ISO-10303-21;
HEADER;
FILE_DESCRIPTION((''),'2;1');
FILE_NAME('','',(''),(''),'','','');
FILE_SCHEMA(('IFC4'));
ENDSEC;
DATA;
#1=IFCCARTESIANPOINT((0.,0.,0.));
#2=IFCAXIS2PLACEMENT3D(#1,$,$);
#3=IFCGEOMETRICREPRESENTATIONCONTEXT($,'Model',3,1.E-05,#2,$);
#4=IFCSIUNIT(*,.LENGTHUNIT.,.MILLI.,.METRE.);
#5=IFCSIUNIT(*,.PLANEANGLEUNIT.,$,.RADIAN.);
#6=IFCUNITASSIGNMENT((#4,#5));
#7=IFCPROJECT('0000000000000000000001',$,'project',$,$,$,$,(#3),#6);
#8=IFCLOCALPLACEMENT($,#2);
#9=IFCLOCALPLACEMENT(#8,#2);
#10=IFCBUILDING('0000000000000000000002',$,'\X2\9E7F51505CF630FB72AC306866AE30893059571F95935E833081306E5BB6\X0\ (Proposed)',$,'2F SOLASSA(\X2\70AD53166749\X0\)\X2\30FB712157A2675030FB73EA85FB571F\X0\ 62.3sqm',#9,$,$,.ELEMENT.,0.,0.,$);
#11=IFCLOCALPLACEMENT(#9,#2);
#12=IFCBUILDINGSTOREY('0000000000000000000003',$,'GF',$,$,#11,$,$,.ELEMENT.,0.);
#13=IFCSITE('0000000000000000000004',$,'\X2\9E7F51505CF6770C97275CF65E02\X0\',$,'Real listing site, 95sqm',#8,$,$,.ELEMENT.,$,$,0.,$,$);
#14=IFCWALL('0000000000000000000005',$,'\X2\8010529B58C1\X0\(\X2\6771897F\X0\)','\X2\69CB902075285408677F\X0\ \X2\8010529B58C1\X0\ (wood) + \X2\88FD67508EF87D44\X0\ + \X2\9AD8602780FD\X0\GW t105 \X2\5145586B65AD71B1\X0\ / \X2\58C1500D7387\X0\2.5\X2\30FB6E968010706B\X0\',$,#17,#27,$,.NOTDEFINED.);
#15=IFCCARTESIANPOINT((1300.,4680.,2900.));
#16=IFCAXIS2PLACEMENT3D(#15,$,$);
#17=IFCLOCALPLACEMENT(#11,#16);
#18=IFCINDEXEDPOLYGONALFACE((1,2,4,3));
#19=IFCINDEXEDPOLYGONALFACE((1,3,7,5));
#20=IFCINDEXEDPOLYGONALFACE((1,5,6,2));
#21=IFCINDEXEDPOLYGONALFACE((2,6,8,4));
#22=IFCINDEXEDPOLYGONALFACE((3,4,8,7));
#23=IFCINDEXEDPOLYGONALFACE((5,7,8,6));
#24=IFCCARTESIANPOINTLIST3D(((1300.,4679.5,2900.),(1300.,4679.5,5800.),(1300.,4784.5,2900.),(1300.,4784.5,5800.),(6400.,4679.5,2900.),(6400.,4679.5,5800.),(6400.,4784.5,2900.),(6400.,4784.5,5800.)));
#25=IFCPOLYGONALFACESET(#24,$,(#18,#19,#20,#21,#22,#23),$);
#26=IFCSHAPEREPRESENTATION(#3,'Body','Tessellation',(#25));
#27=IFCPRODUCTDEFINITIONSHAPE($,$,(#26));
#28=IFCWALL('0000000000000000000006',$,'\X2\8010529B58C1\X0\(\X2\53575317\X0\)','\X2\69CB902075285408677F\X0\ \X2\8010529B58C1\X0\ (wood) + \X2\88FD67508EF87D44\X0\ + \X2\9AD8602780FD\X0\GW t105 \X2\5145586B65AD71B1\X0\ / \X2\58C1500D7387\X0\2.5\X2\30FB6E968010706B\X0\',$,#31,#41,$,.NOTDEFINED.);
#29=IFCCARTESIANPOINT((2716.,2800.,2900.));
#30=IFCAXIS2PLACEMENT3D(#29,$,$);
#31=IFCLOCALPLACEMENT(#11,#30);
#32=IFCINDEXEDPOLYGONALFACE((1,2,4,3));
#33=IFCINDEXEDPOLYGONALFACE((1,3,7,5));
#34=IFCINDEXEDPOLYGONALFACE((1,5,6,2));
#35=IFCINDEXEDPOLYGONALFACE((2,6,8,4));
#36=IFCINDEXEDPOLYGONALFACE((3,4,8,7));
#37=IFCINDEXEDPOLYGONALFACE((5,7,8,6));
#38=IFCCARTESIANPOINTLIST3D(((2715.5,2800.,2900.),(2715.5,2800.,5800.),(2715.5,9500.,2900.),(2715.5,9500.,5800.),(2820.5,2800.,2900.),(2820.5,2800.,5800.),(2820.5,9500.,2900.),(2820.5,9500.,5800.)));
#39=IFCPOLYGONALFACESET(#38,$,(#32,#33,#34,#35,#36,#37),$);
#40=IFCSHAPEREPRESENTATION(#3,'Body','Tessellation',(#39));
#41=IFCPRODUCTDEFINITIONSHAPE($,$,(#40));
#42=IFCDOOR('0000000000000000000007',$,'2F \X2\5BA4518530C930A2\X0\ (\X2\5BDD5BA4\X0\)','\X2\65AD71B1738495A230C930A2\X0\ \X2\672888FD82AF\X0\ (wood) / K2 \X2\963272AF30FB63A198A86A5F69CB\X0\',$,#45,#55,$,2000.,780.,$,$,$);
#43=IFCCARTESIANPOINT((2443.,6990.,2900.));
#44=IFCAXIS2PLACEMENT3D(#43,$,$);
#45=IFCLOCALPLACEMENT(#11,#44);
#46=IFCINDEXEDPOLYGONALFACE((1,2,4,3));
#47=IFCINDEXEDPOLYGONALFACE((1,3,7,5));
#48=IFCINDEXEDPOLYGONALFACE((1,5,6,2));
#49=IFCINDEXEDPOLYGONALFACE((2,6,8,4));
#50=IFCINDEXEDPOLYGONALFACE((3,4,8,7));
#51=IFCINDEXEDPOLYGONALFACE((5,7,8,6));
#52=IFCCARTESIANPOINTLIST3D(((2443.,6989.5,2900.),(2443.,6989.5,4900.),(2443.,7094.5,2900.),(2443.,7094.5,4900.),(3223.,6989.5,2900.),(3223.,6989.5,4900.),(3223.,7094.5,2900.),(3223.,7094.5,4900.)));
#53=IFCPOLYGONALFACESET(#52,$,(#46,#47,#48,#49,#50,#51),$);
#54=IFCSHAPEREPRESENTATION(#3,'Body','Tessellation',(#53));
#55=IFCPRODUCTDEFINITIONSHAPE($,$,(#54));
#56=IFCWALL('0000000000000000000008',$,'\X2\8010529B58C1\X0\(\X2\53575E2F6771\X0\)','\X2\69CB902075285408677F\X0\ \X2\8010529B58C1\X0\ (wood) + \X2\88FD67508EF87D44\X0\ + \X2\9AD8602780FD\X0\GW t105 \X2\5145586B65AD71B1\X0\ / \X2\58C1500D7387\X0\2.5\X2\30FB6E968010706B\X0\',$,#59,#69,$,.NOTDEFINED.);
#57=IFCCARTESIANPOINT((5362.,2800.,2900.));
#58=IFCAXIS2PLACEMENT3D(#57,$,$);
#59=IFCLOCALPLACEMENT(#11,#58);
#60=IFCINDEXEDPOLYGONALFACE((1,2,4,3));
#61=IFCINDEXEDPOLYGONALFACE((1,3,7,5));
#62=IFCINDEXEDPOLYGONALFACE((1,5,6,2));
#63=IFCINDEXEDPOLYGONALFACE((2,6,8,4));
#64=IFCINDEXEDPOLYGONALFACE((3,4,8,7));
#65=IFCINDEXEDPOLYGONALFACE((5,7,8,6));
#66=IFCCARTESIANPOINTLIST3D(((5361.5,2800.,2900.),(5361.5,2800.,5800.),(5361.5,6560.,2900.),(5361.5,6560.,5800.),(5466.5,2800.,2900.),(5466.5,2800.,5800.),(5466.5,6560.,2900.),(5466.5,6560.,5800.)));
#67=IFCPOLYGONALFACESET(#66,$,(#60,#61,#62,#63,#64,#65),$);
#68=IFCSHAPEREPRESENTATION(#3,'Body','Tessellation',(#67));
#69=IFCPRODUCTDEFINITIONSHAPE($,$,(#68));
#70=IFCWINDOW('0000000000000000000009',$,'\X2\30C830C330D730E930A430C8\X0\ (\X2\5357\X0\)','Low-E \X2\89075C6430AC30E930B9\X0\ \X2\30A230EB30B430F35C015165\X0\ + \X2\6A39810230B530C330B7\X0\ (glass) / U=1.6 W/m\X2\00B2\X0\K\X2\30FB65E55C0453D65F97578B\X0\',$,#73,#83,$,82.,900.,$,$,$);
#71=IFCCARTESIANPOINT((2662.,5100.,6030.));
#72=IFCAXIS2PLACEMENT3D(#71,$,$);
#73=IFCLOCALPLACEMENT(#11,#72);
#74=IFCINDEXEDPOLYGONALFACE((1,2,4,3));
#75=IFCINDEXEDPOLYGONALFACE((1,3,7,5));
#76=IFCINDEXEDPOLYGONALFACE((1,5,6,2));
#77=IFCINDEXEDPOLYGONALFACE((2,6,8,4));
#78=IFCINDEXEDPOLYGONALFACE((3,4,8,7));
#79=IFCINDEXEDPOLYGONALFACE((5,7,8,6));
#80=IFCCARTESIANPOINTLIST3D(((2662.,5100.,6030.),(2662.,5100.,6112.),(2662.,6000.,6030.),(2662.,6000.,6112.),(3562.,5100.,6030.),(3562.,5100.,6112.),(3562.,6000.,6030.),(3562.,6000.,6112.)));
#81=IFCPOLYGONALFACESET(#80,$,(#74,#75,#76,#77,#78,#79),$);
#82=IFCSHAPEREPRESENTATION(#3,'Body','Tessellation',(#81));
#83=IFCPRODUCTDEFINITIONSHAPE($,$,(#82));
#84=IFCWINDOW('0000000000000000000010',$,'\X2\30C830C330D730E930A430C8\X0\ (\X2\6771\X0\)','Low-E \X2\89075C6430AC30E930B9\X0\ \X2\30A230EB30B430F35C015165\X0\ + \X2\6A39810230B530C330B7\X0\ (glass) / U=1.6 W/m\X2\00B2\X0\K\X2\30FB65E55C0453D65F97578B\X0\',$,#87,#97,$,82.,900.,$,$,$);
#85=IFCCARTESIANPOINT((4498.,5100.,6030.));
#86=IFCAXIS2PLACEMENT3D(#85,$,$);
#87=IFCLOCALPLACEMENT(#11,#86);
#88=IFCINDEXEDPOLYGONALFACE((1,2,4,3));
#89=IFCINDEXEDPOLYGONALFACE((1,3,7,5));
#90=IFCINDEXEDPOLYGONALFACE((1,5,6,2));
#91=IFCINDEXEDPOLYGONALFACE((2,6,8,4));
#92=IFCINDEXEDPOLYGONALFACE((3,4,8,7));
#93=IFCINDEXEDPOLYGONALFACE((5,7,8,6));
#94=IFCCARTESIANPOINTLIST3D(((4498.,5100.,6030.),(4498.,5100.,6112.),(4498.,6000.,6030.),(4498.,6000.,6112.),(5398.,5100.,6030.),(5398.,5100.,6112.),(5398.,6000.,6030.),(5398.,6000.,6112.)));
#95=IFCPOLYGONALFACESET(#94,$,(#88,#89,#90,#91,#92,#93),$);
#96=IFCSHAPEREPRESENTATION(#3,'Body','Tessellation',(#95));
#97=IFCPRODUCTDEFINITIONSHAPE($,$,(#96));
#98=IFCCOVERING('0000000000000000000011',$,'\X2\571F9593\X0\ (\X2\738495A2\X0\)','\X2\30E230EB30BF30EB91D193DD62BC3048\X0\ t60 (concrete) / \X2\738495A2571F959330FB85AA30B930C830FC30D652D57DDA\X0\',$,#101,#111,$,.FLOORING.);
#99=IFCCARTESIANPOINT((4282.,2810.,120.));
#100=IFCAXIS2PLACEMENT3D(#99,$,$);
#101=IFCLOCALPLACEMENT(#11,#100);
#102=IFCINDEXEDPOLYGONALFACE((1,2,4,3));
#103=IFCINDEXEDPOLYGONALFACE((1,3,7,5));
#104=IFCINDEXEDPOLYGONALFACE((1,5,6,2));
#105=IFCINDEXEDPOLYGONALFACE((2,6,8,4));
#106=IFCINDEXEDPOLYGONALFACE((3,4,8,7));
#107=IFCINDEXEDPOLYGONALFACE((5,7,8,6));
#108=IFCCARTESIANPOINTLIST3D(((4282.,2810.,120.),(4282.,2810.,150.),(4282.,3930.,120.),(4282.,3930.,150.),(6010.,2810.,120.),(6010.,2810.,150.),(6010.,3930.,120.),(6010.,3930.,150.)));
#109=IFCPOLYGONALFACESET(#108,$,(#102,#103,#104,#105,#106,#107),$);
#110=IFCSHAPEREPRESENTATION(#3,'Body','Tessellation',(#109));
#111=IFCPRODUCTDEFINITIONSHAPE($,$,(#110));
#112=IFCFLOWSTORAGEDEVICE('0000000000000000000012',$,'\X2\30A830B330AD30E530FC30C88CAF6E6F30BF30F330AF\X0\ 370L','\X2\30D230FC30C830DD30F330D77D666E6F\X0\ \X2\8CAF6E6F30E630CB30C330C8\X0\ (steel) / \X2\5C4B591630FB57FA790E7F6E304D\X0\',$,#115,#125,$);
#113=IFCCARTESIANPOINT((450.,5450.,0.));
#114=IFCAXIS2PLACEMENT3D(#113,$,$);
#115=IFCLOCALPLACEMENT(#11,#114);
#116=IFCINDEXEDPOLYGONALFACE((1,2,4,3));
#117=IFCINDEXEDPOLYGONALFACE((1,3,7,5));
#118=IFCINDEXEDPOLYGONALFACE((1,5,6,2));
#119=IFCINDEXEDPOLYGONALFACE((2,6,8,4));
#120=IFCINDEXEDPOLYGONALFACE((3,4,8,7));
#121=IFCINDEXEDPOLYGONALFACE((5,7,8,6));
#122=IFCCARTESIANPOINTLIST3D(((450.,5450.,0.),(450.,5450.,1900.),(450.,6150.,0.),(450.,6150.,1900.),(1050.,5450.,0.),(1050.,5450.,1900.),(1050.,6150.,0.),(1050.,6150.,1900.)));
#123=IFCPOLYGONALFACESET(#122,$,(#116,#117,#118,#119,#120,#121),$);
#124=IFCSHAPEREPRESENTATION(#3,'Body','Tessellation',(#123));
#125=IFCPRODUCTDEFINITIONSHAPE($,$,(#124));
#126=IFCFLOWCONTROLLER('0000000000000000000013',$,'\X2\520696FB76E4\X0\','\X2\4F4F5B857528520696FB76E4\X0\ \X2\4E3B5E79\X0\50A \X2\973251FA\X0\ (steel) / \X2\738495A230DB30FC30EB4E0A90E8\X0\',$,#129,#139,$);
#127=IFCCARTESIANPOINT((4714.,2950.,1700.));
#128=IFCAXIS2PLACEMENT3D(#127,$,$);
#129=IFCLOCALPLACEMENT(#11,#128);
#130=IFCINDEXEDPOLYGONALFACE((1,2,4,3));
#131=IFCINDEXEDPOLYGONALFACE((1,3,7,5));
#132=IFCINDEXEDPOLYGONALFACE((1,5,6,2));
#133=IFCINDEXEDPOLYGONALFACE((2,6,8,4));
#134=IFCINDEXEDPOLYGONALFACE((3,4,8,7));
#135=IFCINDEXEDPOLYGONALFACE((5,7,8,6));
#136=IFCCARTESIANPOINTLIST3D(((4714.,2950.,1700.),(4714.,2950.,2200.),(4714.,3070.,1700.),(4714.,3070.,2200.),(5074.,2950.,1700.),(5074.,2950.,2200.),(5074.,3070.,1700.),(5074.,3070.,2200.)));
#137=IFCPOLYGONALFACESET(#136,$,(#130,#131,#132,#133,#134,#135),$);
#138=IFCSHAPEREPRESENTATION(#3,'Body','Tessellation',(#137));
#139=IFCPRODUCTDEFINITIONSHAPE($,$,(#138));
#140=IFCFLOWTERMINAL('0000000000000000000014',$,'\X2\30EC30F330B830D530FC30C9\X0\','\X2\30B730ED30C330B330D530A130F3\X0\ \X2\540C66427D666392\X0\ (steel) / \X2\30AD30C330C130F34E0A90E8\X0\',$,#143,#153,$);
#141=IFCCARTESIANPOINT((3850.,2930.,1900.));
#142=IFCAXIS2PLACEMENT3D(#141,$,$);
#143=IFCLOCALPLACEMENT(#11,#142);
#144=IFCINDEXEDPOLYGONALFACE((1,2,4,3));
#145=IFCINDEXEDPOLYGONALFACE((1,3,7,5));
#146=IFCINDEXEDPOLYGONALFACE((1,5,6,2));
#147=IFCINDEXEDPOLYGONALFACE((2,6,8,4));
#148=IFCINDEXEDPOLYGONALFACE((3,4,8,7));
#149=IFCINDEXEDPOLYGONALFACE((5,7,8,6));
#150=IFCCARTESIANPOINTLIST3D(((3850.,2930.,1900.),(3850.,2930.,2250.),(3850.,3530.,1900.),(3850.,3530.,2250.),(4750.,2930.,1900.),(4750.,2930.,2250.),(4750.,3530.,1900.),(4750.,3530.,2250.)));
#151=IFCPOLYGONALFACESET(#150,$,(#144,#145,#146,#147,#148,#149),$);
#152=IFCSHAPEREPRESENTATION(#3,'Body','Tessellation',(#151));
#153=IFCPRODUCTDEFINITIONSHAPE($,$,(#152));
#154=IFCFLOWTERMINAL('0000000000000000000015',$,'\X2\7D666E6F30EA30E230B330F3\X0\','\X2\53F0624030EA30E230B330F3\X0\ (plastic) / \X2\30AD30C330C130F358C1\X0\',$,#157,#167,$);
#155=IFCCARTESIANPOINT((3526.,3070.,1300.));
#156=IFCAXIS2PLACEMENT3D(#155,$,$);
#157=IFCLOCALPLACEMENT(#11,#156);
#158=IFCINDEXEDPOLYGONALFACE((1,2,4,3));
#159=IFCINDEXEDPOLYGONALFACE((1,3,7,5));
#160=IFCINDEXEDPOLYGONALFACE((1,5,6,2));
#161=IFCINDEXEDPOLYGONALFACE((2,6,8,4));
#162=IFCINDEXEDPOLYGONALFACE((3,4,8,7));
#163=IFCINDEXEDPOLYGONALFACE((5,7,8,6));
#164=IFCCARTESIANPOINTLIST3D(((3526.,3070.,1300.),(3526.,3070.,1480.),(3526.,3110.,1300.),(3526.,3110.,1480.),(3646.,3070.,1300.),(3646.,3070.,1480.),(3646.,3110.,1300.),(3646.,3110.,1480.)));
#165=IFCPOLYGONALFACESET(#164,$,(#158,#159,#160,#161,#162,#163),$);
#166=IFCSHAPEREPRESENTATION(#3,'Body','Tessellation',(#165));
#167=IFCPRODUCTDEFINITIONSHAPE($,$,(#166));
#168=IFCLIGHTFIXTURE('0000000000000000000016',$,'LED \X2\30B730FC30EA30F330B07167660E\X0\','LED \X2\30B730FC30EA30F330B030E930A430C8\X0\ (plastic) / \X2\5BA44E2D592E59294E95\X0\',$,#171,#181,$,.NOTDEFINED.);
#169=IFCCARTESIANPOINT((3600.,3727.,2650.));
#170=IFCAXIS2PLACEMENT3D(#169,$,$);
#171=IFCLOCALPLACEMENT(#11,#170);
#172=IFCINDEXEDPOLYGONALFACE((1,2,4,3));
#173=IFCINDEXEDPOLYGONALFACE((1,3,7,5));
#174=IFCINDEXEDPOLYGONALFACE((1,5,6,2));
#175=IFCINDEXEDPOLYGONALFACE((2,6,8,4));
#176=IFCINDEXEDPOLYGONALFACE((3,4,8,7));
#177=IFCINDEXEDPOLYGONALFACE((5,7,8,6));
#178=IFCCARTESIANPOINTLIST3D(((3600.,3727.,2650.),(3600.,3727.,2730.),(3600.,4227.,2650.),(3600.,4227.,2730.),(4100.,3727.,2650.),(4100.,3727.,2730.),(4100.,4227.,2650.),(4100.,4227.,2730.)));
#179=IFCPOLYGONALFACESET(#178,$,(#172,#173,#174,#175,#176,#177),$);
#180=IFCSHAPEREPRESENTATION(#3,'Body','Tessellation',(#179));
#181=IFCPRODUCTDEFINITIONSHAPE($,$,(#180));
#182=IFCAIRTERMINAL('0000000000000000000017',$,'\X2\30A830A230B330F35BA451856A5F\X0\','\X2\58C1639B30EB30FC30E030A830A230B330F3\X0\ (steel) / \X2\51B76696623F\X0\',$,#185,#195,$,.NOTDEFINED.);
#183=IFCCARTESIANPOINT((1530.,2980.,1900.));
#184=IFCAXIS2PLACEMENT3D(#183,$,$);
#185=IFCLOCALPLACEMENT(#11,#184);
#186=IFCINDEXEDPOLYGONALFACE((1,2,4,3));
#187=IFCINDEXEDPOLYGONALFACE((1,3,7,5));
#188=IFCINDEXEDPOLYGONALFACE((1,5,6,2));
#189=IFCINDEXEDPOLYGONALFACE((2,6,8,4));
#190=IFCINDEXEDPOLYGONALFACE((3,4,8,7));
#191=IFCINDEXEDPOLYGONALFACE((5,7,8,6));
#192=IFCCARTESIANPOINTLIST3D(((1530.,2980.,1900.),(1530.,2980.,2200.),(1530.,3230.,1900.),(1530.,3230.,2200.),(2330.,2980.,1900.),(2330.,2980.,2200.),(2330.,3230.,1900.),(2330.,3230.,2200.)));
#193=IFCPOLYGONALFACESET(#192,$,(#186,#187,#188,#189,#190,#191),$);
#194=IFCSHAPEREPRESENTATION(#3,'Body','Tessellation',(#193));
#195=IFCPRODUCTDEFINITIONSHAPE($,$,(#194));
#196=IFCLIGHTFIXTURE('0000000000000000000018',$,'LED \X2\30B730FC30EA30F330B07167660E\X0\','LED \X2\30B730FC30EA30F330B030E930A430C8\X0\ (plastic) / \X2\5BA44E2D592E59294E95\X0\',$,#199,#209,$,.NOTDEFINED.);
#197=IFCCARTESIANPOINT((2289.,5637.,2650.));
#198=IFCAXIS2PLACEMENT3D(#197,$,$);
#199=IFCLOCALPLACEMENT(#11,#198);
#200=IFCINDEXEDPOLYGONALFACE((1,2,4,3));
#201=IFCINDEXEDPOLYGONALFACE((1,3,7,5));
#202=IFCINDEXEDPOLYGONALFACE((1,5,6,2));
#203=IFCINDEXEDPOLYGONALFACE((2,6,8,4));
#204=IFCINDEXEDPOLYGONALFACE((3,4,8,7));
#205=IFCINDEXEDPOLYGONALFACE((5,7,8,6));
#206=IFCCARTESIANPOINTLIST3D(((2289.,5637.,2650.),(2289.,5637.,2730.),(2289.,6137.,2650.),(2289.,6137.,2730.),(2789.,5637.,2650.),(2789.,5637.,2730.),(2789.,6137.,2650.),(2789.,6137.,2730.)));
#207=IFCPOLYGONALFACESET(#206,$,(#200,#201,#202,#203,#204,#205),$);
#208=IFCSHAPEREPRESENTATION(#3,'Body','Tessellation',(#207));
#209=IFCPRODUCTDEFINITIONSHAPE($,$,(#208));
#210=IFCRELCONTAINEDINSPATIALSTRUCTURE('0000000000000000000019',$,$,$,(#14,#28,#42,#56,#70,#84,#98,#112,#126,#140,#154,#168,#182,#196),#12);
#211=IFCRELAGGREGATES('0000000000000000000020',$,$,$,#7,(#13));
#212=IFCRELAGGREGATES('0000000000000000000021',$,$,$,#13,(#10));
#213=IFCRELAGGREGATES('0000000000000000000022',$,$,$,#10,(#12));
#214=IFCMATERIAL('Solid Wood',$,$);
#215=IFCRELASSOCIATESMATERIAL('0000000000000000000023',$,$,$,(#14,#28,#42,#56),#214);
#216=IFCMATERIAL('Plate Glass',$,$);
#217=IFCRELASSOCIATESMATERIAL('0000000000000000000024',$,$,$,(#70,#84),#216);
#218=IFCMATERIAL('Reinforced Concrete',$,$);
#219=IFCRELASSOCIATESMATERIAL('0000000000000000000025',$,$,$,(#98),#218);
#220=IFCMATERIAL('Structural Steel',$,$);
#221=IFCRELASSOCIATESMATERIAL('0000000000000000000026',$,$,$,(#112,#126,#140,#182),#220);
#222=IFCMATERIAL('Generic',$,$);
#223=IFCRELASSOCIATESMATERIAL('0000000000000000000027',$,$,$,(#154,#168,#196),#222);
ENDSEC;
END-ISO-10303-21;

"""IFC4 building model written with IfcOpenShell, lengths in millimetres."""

from ifc_helpers import new_model, si_unit, frame, frame_2d, origin, place, context, project, spatial, rectangle, extrude, material, element, fill, save


model = new_model("IFC4")

# Units and contexts
model_context = context("Model", 3, precision=1e-05, world=origin())
ifc_project = project(units=[si_unit("LENGTHUNIT", "METRE", prefix="MILLI"), si_unit("PLANEANGLEUNIT", "RADIAN")], contexts=[model_context])

# Site, building, storey
site_placement = place(None, origin())
site = spatial("IfcSite", under=ifc_project, at=site_placement, Name="鹿児島県霧島市", ObjectType="Real listing site, 95sqm", CompositionType="ELEMENT", RefElevation=0.0)
building_placement = place(site_placement, origin())
building = spatial("IfcBuilding", under=site, at=building_placement, Name="鹿児島・犬と暮らす土間広めの家 (Proposed)", ObjectType="2F SOLASSA(炭化杉)・無垢材・珪藻土 62.3sqm", CompositionType="ELEMENT", ElevationOfRefHeight=0.0, ElevationOfTerrain=0.0)
storey_placement = place(building_placement, origin())
storey = spatial("IfcBuildingStorey", under=building, at=storey_placement, Name="GF", CompositionType="ELEMENT", Elevation=0.0)

# Shared definitions
ifc_material_1 = material(Name="Solid Wood")

# Wall
wall_1_placement = place(storey_placement, frame((1300.0, 4680.0, 2900.0)))
element("IfcWall", 1, at=wall_1_placement, inside=storey, material=ifc_material_1, Name="耐力壁(東西)", Description="構造用合板 耐力壁 (wood) + 製材軸組 + 高性能GW t105 充填断熱 / 壁倍率2.5・準耐火", PredefinedType="NOTDEFINED", context=model_context, shape_type="SweptSolid", body=[
    extrude(rectangle(XDim=5100.0, YDim=105.0, at=frame_2d((2550.0, 52.0))), frame((1300.0, 4680.0, 2900.0)), (0.0, 0.0, 1.0), 2900.0),
])

# Wall, opening, door
wall_2_placement = place(storey_placement, frame((2716.0, 2800.0, 2900.0)))
wall_2 = element("IfcWall", 2, at=wall_2_placement, inside=storey, material=ifc_material_1, Name="耐力壁(南北)", Description="構造用合板 耐力壁 (wood) + 製材軸組 + 高性能GW t105 充填断熱 / 壁倍率2.5・準耐火", PredefinedType="NOTDEFINED", context=model_context, shape_type="SweptSolid", body=[
    extrude(rectangle(XDim=105.0, YDim=6700.0, at=frame_2d((52.0, 3350.0))), frame((2716.0, 2800.0, 2900.0)), (0.0, 0.0, 1.0), 2900.0),
])
opening_placement = place(storey_placement, frame((2443.0, 6990.0, 2900.0)))
opening = element("IfcOpeningElement", 3, at=opening_placement, cuts=wall_2, PredefinedType="NOTDEFINED", context=model_context, shape_type="SweptSolid", body=[
    extrude(rectangle(XDim=780.0, YDim=105.0, at=frame_2d((390.0, 52.0))), frame((2443.0, 6990.0, 2900.0)), (0.0, 0.0, 1.0), 2000.0),
])
door_placement = place(storey_placement, frame((2443.0, 6990.0, 2900.0)))
door = element("IfcDoor", 4, at=door_placement, inside=storey, material=ifc_material_1, Name="2F 室内ドア (寝室)", Description="断熱玄関ドア 木製芯 (wood) / K2 防犯・採風機構", OverallHeight=2000.0, OverallWidth=780.0, context=model_context, shape_type="SweptSolid", body=[
    extrude(rectangle(XDim=780.0, YDim=105.0, at=frame_2d((390.0, 52.0))), frame((2443.0, 6990.0, 2900.0)), (0.0, 0.0, 1.0), 2000.0),
])
fill(opening, door)

# Wall
wall_3_placement = place(storey_placement, frame((5362.0, 2800.0, 2900.0)))
element("IfcWall", 5, at=wall_3_placement, inside=storey, material=ifc_material_1, Name="耐力壁(南帯東)", Description="構造用合板 耐力壁 (wood) + 製材軸組 + 高性能GW t105 充填断熱 / 壁倍率2.5・準耐火", PredefinedType="NOTDEFINED", context=model_context, shape_type="SweptSolid", body=[
    extrude(rectangle(XDim=105.0, YDim=3760.0, at=frame_2d((52.0, 1880.0))), frame((5362.0, 2800.0, 2900.0)), (0.0, 0.0, 1.0), 2900.0),
])

# Windows
ifc_material_2 = material(Name="Plate Glass")
window_1_placement = place(storey_placement, frame((2662.0, 5100.0, 6030.0)))
element("IfcWindow", 6, at=window_1_placement, inside=storey, material=ifc_material_2, Name="トップライト (南)", Description="Low-E 複層ガラス アルゴン封入 + 樹脂サッシ (glass) / U=1.6 W/m²K・日射取得型", OverallHeight=82.0, OverallWidth=900.0, context=model_context, shape_type="SweptSolid", body=[
    extrude(rectangle(XDim=900.0, YDim=900.0, at=frame_2d((450.0, 450.0))), frame((2662.0, 5100.0, 6030.0)), (0.0, 0.0, 1.0), 82.0),
])
window_2_placement = place(storey_placement, frame((4498.0, 5100.0, 6030.0)))
element("IfcWindow", 7, at=window_2_placement, inside=storey, material=ifc_material_2, Name="トップライト (東)", Description="Low-E 複層ガラス アルゴン封入 + 樹脂サッシ (glass) / U=1.6 W/m²K・日射取得型", OverallHeight=82.0, OverallWidth=900.0, context=model_context, shape_type="SweptSolid", body=[
    extrude(rectangle(XDim=900.0, YDim=900.0, at=frame_2d((450.0, 450.0))), frame((4498.0, 5100.0, 6030.0)), (0.0, 0.0, 1.0), 82.0),
])

# Covering
ifc_material_3 = material(Name="Reinforced Concrete")
covering_placement = place(storey_placement, frame((4282.0, 2810.0, 120.0)))
element("IfcCovering", 8, at=covering_placement, inside=storey, material=ifc_material_3, Name="土間 (玄関)", Description="モルタル金鏝押え t60 (concrete) / 玄関土間・薪ストーブ動線", PredefinedType="FLOORING", context=model_context, shape_type="SweptSolid", body=[
    extrude(rectangle(XDim=1728.0, YDim=1120.0, at=frame_2d((864.0, 560.0))), frame((4282.0, 2810.0, 120.0)), (0.0, 0.0, 1.0), 30.0),
])

# Flow storage device
ifc_material_4 = material(Name="Structural Steel")
flow_storage_device_placement = place(storey_placement, frame((450.0, 5450.0, 0.0)))
element("IfcFlowStorageDevice", 9, at=flow_storage_device_placement, inside=storey, material=ifc_material_4, Name="エコキュート貯湯タンク 370L", Description="ヒートポンプ給湯 貯湯ユニット (steel) / 屋外・基礎置き", context=model_context, shape_type="SweptSolid", body=[
    extrude(rectangle(XDim=600.0, YDim=700.0, at=frame_2d((300.0, 350.0))), frame((450.0, 5450.0, 0.0)), (0.0, 0.0, 1.0), 1900.0),
])

# Flow controller
flow_controller_placement = place(storey_placement, frame((4714.0, 2950.0, 1700.0)))
element("IfcFlowController", 10, at=flow_controller_placement, inside=storey, material=ifc_material_4, Name="分電盤", Description="住宅用分電盤 主幹50A 露出 (steel) / 玄関ホール上部", context=model_context, shape_type="SweptSolid", body=[
    extrude(rectangle(XDim=360.0, YDim=120.0, at=frame_2d((180.0, 60.0))), frame((4714.0, 2950.0, 1700.0)), (0.0, 0.0, 1.0), 500.0),
])

# Flow terminals
flow_terminal_1_placement = place(storey_placement, frame((3850.0, 2930.0, 1900.0)))
element("IfcFlowTerminal", 11, at=flow_terminal_1_placement, inside=storey, material=ifc_material_4, Name="レンジフード", Description="シロッコファン 同時給排 (steel) / キッチン上部", context=model_context, shape_type="SweptSolid", body=[
    extrude(rectangle(XDim=900.0, YDim=600.0, at=frame_2d((450.0, 300.0))), frame((3850.0, 2930.0, 1900.0)), (0.0, 0.0, 1.0), 350.0),
])
ifc_material_5 = material(Name="Generic")
flow_terminal_2_placement = place(storey_placement, frame((3526.0, 3070.0, 1300.0)))
element("IfcFlowTerminal", 12, at=flow_terminal_2_placement, inside=storey, material=ifc_material_5, Name="給湯リモコン", Description="台所リモコン (plastic) / キッチン壁", context=model_context, shape_type="SweptSolid", body=[
    extrude(rectangle(XDim=120.0, YDim=40.0, at=frame_2d((60.0, 20.0))), frame((3526.0, 3070.0, 1300.0)), (0.0, 0.0, 1.0), 180.0),
])

# Light fixture
light_fixture_1_placement = place(storey_placement, frame((3600.0, 3727.0, 2650.0)))
element("IfcLightFixture", 13, at=light_fixture_1_placement, inside=storey, material=ifc_material_5, Name="LED シーリング照明", Description="LED シーリングライト (plastic) / 室中央天井", PredefinedType="NOTDEFINED", context=model_context, shape_type="SweptSolid", body=[
    extrude(rectangle(XDim=500.0, YDim=500.0, at=frame_2d((250.0, 250.0))), frame((3600.0, 3727.0, 2650.0)), (0.0, 0.0, 1.0), 80.0),
])

# Air terminal
air_terminal_1_placement = place(storey_placement, frame((1530.0, 2980.0, 1900.0)))
element("IfcAirTerminal", 14, at=air_terminal_1_placement, inside=storey, material=ifc_material_4, Name="エアコン室内機", Description="壁掛ルームエアコン (steel) / 冷暖房", PredefinedType="NOTDEFINED", context=model_context, shape_type="SweptSolid", body=[
    extrude(rectangle(XDim=800.0, YDim=250.0, at=frame_2d((400.0, 125.0))), frame((1530.0, 2980.0, 1900.0)), (0.0, 0.0, 1.0), 300.0),
])

# Light fixture
light_fixture_2_placement = place(storey_placement, frame((2289.0, 5637.0, 2650.0)))
element("IfcLightFixture", 15, at=light_fixture_2_placement, inside=storey, material=ifc_material_5, Name="LED シーリング照明", Description="LED シーリングライト (plastic) / 室中央天井", PredefinedType="NOTDEFINED", context=model_context, shape_type="SweptSolid", body=[
    extrude(rectangle(XDim=500.0, YDim=500.0, at=frame_2d((250.0, 250.0))), frame((2289.0, 5637.0, 2650.0)), (0.0, 0.0, 1.0), 80.0),
])

save(model, "model.ifc")
